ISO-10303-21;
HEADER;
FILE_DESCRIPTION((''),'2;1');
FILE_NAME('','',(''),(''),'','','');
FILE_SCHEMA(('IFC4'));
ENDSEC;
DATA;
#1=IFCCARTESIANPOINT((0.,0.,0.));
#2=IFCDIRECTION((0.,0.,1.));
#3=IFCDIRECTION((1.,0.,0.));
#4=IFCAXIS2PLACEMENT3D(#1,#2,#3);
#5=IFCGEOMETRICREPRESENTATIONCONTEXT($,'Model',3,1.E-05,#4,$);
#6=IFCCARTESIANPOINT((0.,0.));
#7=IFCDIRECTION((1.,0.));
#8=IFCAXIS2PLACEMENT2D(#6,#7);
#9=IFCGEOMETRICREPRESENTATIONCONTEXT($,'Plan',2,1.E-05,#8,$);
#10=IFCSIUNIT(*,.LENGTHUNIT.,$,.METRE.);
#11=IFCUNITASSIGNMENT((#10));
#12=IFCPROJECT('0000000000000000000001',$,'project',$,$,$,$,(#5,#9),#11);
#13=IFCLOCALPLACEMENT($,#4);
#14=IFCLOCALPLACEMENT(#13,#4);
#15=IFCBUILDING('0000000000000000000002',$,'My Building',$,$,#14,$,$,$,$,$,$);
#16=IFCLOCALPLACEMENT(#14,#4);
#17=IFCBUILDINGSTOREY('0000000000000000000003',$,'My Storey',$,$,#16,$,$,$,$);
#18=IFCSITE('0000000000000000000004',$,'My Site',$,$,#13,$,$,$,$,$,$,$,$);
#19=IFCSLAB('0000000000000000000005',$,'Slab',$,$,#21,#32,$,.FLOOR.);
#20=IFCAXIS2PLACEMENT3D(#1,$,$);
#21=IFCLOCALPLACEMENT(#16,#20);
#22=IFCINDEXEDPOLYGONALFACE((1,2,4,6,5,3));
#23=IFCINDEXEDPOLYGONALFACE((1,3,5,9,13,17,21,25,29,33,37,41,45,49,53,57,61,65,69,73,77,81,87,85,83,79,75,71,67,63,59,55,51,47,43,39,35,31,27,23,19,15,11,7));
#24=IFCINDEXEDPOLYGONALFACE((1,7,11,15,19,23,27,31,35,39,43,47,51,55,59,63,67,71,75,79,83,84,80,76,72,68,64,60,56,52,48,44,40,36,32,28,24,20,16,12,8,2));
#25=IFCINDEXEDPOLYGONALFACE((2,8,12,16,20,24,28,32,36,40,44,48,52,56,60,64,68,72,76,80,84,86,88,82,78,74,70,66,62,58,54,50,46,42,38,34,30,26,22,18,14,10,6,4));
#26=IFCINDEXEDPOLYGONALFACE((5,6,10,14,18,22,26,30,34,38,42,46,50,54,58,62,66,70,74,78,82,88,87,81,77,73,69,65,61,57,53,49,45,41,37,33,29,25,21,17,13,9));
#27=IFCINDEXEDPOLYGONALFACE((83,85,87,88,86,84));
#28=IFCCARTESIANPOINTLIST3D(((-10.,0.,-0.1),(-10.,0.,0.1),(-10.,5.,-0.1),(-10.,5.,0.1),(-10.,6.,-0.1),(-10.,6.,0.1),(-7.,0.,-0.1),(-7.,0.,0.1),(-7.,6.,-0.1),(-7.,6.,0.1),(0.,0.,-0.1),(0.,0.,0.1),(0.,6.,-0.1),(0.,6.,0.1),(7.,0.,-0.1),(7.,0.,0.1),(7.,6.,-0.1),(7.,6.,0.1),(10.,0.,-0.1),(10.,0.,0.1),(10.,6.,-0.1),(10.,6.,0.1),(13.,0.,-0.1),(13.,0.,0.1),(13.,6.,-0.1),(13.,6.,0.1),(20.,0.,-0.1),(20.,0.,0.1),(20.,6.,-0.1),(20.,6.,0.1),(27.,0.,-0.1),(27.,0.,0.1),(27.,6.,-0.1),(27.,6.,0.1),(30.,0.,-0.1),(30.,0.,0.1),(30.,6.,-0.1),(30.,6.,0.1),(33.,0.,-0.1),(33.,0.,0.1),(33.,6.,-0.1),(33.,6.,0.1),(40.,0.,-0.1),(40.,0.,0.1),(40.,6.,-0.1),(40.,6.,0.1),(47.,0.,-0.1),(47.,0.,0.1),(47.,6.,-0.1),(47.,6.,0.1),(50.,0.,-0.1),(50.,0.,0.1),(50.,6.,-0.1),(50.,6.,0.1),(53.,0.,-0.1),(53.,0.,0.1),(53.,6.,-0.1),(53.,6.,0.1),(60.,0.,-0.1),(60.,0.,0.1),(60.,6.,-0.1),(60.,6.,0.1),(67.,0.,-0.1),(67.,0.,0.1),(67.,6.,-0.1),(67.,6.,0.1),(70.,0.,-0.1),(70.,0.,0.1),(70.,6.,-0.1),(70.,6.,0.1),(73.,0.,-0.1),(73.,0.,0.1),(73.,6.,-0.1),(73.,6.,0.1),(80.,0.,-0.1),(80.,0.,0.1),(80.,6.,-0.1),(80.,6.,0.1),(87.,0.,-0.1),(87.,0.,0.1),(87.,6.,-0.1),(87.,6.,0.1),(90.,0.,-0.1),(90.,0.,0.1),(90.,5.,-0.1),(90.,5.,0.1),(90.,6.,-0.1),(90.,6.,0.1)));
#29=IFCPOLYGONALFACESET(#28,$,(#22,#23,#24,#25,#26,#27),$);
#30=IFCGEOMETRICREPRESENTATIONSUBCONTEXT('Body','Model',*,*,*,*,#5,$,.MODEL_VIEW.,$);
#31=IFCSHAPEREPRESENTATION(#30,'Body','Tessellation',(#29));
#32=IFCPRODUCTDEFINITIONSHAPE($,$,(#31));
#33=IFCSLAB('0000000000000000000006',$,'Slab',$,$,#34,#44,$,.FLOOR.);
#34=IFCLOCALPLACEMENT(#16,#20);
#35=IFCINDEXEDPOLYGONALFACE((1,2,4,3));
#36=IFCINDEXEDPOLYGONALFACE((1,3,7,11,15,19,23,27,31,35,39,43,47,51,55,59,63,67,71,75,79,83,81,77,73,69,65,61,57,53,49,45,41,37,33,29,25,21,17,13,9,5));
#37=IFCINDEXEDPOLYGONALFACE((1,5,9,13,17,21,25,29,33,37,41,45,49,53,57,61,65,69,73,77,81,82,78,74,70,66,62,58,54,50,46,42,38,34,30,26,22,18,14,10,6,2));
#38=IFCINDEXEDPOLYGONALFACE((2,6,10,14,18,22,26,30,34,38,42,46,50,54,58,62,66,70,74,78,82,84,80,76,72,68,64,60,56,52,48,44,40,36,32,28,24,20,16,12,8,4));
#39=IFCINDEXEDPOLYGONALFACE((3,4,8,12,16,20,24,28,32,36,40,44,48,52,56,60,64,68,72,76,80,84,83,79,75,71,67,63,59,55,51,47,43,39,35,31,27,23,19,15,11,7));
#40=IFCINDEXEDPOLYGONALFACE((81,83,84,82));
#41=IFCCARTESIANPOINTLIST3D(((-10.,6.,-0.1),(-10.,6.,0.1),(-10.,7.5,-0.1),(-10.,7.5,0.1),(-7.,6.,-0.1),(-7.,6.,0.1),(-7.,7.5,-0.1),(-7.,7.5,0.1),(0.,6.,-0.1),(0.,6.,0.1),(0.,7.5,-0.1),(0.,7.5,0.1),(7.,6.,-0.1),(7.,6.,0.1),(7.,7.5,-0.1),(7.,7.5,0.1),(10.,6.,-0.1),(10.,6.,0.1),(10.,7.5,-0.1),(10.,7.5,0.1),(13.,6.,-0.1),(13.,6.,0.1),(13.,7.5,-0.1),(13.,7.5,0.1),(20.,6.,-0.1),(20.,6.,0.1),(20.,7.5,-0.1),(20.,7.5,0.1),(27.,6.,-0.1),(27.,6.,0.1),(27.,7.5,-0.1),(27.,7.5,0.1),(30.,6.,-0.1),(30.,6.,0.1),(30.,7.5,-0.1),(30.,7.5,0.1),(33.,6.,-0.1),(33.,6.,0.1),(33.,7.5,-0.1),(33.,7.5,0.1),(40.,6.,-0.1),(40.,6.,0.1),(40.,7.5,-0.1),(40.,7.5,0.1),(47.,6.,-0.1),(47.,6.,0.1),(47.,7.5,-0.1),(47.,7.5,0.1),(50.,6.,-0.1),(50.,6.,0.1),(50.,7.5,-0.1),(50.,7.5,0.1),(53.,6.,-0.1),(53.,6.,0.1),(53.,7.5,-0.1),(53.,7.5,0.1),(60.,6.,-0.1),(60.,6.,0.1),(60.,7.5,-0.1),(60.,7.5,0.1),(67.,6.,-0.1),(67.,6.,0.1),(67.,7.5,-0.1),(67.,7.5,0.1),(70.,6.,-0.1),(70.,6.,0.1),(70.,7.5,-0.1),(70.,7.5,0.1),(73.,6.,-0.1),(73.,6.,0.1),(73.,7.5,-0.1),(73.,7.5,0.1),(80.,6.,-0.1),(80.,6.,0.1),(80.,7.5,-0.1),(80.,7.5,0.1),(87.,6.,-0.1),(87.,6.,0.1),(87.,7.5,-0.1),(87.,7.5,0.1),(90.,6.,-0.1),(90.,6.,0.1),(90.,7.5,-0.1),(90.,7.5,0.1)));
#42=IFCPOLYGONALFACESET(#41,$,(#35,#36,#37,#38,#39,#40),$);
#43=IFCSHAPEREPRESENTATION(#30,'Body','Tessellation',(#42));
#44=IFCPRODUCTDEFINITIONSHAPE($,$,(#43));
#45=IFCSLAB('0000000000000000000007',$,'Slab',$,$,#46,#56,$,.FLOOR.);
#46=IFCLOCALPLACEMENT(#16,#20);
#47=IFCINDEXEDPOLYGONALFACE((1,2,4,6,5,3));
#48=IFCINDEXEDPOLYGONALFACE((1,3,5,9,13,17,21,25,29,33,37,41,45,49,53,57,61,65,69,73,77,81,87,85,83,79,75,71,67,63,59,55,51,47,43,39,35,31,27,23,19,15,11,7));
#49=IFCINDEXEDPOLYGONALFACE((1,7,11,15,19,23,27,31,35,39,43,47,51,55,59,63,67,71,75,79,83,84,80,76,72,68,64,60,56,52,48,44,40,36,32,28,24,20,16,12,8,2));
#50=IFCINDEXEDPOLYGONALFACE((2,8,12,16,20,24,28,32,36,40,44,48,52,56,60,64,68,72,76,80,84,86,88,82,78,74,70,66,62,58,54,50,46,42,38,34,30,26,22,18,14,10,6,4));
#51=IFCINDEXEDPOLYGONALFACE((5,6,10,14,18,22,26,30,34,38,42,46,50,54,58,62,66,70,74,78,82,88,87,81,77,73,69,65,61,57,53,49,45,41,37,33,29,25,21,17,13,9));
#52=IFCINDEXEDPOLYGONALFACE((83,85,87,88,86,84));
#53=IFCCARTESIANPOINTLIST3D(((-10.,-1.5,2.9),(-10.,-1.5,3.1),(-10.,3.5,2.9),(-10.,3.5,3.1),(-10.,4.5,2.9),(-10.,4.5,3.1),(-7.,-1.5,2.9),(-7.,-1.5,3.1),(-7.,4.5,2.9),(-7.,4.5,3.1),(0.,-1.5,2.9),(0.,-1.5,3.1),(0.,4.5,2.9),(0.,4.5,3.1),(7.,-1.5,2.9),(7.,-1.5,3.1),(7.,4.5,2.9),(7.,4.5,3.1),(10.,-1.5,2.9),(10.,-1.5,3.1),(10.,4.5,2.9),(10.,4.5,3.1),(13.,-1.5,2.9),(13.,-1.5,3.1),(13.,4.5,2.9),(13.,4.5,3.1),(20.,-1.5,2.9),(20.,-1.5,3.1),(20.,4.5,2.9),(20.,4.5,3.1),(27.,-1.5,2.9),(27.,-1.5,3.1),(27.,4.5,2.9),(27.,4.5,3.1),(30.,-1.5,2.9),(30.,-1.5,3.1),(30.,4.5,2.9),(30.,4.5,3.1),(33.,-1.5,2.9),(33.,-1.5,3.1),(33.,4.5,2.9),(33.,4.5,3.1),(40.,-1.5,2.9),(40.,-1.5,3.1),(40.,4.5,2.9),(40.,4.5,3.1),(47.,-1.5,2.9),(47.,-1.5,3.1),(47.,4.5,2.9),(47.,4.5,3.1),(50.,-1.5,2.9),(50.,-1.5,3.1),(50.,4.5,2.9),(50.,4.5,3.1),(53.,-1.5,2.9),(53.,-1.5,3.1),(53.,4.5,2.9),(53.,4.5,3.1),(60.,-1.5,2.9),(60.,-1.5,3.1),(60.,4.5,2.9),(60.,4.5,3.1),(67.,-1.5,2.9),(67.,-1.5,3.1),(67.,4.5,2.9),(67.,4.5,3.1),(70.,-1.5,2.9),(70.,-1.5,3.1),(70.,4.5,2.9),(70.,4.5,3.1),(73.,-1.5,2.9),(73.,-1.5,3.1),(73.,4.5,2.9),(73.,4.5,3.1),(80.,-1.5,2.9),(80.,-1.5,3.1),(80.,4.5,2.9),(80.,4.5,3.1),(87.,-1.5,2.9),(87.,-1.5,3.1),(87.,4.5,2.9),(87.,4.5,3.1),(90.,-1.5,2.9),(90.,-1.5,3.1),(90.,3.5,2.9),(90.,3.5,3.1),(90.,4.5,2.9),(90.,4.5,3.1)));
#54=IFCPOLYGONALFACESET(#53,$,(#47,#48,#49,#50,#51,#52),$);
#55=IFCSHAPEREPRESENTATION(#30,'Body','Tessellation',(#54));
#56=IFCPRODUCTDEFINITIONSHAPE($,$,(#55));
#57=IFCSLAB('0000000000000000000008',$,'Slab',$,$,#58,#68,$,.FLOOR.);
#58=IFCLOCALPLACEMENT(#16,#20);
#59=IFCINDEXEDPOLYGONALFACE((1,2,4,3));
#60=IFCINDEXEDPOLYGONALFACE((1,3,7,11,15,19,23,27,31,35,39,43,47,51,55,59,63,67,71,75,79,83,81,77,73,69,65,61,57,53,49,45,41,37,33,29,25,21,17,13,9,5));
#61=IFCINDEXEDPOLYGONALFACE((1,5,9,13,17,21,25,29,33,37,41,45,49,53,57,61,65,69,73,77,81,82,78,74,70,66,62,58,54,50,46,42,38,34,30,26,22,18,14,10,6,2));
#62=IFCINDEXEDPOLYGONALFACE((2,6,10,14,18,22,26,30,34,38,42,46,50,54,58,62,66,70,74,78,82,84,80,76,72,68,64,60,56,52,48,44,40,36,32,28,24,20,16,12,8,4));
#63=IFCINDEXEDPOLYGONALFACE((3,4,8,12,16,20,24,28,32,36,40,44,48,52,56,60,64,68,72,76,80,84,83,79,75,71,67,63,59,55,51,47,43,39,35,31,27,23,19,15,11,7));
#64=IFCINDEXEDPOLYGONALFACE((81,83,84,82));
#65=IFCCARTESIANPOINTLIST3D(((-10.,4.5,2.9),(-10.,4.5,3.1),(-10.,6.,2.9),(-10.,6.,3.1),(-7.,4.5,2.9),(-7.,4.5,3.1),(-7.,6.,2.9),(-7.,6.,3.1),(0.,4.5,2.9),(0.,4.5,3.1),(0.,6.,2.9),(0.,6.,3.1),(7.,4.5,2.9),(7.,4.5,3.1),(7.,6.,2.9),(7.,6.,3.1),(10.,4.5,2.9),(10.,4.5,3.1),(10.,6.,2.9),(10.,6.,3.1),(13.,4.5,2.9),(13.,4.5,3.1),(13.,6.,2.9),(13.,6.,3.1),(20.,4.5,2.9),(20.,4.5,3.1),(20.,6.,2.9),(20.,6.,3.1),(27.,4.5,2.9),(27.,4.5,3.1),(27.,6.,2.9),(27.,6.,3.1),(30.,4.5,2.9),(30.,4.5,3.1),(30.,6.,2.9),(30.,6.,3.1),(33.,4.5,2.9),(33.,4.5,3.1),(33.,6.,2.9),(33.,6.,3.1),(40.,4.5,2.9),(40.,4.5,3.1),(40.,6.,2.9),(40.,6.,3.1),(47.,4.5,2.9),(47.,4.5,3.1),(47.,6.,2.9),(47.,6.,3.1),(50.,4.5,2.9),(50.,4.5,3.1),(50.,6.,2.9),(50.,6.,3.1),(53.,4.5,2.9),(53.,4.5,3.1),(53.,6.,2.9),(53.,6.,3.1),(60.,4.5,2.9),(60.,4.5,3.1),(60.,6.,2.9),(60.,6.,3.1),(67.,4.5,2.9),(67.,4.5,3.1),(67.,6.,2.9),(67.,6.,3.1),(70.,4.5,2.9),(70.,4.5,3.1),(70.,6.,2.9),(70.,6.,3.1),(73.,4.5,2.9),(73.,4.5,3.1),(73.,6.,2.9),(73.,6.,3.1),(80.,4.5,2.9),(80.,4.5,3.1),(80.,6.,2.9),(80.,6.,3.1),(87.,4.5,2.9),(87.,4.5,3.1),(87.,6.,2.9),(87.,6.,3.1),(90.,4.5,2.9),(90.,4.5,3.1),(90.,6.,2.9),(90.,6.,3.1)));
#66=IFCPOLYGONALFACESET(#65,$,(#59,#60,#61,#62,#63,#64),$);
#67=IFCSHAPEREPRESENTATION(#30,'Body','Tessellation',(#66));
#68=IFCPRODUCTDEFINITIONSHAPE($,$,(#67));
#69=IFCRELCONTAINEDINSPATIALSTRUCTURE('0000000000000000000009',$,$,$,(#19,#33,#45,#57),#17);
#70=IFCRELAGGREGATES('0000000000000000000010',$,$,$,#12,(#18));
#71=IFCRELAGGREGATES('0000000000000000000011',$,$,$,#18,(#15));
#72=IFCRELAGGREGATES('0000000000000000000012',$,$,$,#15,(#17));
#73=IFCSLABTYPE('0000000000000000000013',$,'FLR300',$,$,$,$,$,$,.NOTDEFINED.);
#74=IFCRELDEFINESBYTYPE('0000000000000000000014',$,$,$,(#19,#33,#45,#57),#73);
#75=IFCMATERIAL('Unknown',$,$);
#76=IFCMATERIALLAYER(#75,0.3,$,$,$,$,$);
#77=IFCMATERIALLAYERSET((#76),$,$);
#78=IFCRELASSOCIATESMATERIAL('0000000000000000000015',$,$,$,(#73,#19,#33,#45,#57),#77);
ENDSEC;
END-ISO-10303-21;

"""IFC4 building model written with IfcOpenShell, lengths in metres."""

from ifc_helpers import new_model, si_unit, frame, origin, origin_with_axes, origin_2d_with_axis, place, context, subcontext, project, spatial, polyline, outline, extrude, material, layer, layer_set, layer_usage, type_object, element, save


model = new_model("IFC4")

# Units and contexts
model_context = context("Model", 3, precision=1e-05, world=origin_with_axes())
plan_context = context("Plan", 2, precision=1e-05, world=origin_2d_with_axis())
body_context = subcontext(model_context, "Body", "Model", "MODEL_VIEW")
ifc_project = project(units=[si_unit("LENGTHUNIT", "METRE")], contexts=[model_context, plan_context])

# Site, building, storey
site_placement = place(None, origin_with_axes())
site = spatial("IfcSite", under=ifc_project, at=site_placement, Name="My Site")
building_placement = place(site_placement, origin_with_axes())
building = spatial("IfcBuilding", under=site, at=building_placement, Name="My Building")
storey_placement = place(building_placement, origin_with_axes())
storey = spatial("IfcBuildingStorey", under=building, at=storey_placement, Name="My Storey")

# Slabs
ifc_material = material(Name="Unknown")
ifc_layer_1 = layer(ifc_material, 0.3)
ifc_layer_set_1 = layer_set([ifc_layer_1])
ifc_layer_usage_1 = layer_usage(ifc_layer_set_1, "AXIS3", "POSITIVE", 0.0)
slab_type = type_object("IfcSlabType", Name="FLR300", PredefinedType="NOTDEFINED", material=ifc_layer_set_1)
slab_1_placement = place(storey_placement, frame((40.0, 3.0909, -0.1), z_axis=(0.0, 0.0, 1.0), x_axis=(1.0, 0.0, 0.0)))
element("IfcSlab", 1, at=slab_1_placement, inside=storey, type_object=slab_type, material=ifc_layer_usage_1, Name="Slab", PredefinedType="FLOOR", context=body_context, shape_type="SweptSolid", body=[
    extrude(outline(polyline([(-47.0, 2.9091), (-50.0, 2.9091), (-50.0, 1.9091), (-50.0, -3.0909), (-47.0, -3.0909), (-40.0, -3.0909), (-33.0, -3.0909), (-30.0, -3.0909), (-27.0, -3.0909), (-20.0, -3.0909), (-13.0, -3.0909), (-10.0, -3.0909), (-7.0, -3.0909), (0.0, -3.0909), (7.0, -3.0909), (10.0, -3.0909), (13.0, -3.0909), (20.0, -3.0909), (27.0, -3.0909), (30.0, -3.0909), (33.0, -3.0909), (40.0, -3.0909), (47.0, -3.0909), (50.0, -3.0909), (50.0, 1.9091), (50.0, 2.9091), (47.0, 2.9091), (40.0, 2.9091), (33.0, 2.9091), (30.0, 2.9091), (27.0, 2.9091), (20.0, 2.9091), (13.0, 2.9091), (10.0, 2.9091), (7.0, 2.9091), (0.0, 2.9091), (-7.0, 2.9091), (-10.0, 2.9091), (-13.0, 2.9091), (-20.0, 2.9091), (-27.0, 2.9091), (-30.0, 2.9091), (-33.0, 2.9091), (-40.0, 2.9091), (-47.0, 2.9091)])), origin(), (0.0, 0.0, 1.0), 0.2),
])
ifc_layer_usage_2 = layer_usage(ifc_layer_set_1, "AXIS3", "POSITIVE", 0.0)
slab_2_placement = place(storey_placement, frame((40.0, 6.75, -0.1), z_axis=(0.0, 0.0, 1.0), x_axis=(1.0, 0.0, 0.0)))
element("IfcSlab", 2, at=slab_2_placement, inside=storey, type_object=slab_type, material=ifc_layer_usage_2, Name="Slab", PredefinedType="FLOOR", context=body_context, shape_type="SweptSolid", body=[
    extrude(outline(polyline([(-40.0, -0.75), (-33.0, -0.75), (-30.0, -0.75), (-27.0, -0.75), (-20.0, -0.75), (-13.0, -0.75), (-10.0, -0.75), (-7.0, -0.75), (0.0, -0.75), (7.0, -0.75), (10.0, -0.75), (13.0, -0.75), (20.0, -0.75), (27.0, -0.75), (30.0, -0.75), (33.0, -0.75), (40.0, -0.75), (47.0, -0.75), (50.0, -0.75), (50.0, 0.75), (47.0, 0.75), (40.0, 0.75), (33.0, 0.75), (30.0, 0.75), (27.0, 0.75), (20.0, 0.75), (13.0, 0.75), (10.0, 0.75), (7.0, 0.75), (0.0, 0.75), (-7.0, 0.75), (-10.0, 0.75), (-13.0, 0.75), (-20.0, 0.75), (-27.0, 0.75), (-30.0, 0.75), (-33.0, 0.75), (-40.0, 0.75), (-47.0, 0.75), (-50.0, 0.75), (-50.0, -0.75), (-47.0, -0.75), (-40.0, -0.75)])), origin(), (0.0, 0.0, 1.0), 0.2),
])
ifc_layer_usage_3 = layer_usage(ifc_layer_set_1, "AXIS3", "POSITIVE", 0.0)
slab_3_placement = place(storey_placement, frame((40.0, 1.5909, 2.9), z_axis=(0.0, 0.0, 1.0), x_axis=(1.0, 0.0, 0.0)))
element("IfcSlab", 3, at=slab_3_placement, inside=storey, type_object=slab_type, material=ifc_layer_usage_3, Name="Slab", PredefinedType="FLOOR", context=body_context, shape_type="SweptSolid", body=[
    extrude(outline(polyline([(-47.0, 2.9091), (-50.0, 2.9091), (-50.0, 1.9091), (-50.0, -3.0909), (-47.0, -3.0909), (-40.0, -3.0909), (-33.0, -3.0909), (-30.0, -3.0909), (-27.0, -3.0909), (-20.0, -3.0909), (-13.0, -3.0909), (-10.0, -3.0909), (-7.0, -3.0909), (0.0, -3.0909), (7.0, -3.0909), (10.0, -3.0909), (13.0, -3.0909), (20.0, -3.0909), (27.0, -3.0909), (30.0, -3.0909), (33.0, -3.0909), (40.0, -3.0909), (47.0, -3.0909), (50.0, -3.0909), (50.0, 1.9091), (50.0, 2.9091), (47.0, 2.9091), (40.0, 2.9091), (33.0, 2.9091), (30.0, 2.9091), (27.0, 2.9091), (20.0, 2.9091), (13.0, 2.9091), (10.0, 2.9091), (7.0, 2.9091), (0.0, 2.9091), (-7.0, 2.9091), (-10.0, 2.9091), (-13.0, 2.9091), (-20.0, 2.9091), (-27.0, 2.9091), (-30.0, 2.9091), (-33.0, 2.9091), (-40.0, 2.9091), (-47.0, 2.9091)])), origin(), (0.0, 0.0, 1.0), 0.2),
])
ifc_layer_usage_4 = layer_usage(ifc_layer_set_1, "AXIS3", "POSITIVE", 0.0)
slab_4_placement = place(storey_placement, frame((40.0, 5.25, 2.9), z_axis=(0.0, 0.0, 1.0), x_axis=(1.0, 0.0, 0.0)))
element("IfcSlab", 4, at=slab_4_placement, inside=storey, type_object=slab_type, material=ifc_layer_usage_4, Name="Slab", PredefinedType="FLOOR", context=body_context, shape_type="SweptSolid", body=[
    extrude(outline(polyline([(-40.0, -0.75), (-33.0, -0.75), (-30.0, -0.75), (-27.0, -0.75), (-20.0, -0.75), (-13.0, -0.75), (-10.0, -0.75), (-7.0, -0.75), (0.0, -0.75), (7.0, -0.75), (10.0, -0.75), (13.0, -0.75), (20.0, -0.75), (27.0, -0.75), (30.0, -0.75), (33.0, -0.75), (40.0, -0.75), (47.0, -0.75), (50.0, -0.75), (50.0, 0.75), (47.0, 0.75), (40.0, 0.75), (33.0, 0.75), (30.0, 0.75), (27.0, 0.75), (20.0, 0.75), (13.0, 0.75), (10.0, 0.75), (7.0, 0.75), (0.0, 0.75), (-7.0, 0.75), (-10.0, 0.75), (-13.0, 0.75), (-20.0, 0.75), (-27.0, 0.75), (-30.0, 0.75), (-33.0, 0.75), (-40.0, 0.75), (-47.0, 0.75), (-50.0, 0.75), (-50.0, -0.75), (-47.0, -0.75), (-40.0, -0.75)])), origin(), (0.0, 0.0, 1.0), 0.2),
])

save(model, "model.ifc")
